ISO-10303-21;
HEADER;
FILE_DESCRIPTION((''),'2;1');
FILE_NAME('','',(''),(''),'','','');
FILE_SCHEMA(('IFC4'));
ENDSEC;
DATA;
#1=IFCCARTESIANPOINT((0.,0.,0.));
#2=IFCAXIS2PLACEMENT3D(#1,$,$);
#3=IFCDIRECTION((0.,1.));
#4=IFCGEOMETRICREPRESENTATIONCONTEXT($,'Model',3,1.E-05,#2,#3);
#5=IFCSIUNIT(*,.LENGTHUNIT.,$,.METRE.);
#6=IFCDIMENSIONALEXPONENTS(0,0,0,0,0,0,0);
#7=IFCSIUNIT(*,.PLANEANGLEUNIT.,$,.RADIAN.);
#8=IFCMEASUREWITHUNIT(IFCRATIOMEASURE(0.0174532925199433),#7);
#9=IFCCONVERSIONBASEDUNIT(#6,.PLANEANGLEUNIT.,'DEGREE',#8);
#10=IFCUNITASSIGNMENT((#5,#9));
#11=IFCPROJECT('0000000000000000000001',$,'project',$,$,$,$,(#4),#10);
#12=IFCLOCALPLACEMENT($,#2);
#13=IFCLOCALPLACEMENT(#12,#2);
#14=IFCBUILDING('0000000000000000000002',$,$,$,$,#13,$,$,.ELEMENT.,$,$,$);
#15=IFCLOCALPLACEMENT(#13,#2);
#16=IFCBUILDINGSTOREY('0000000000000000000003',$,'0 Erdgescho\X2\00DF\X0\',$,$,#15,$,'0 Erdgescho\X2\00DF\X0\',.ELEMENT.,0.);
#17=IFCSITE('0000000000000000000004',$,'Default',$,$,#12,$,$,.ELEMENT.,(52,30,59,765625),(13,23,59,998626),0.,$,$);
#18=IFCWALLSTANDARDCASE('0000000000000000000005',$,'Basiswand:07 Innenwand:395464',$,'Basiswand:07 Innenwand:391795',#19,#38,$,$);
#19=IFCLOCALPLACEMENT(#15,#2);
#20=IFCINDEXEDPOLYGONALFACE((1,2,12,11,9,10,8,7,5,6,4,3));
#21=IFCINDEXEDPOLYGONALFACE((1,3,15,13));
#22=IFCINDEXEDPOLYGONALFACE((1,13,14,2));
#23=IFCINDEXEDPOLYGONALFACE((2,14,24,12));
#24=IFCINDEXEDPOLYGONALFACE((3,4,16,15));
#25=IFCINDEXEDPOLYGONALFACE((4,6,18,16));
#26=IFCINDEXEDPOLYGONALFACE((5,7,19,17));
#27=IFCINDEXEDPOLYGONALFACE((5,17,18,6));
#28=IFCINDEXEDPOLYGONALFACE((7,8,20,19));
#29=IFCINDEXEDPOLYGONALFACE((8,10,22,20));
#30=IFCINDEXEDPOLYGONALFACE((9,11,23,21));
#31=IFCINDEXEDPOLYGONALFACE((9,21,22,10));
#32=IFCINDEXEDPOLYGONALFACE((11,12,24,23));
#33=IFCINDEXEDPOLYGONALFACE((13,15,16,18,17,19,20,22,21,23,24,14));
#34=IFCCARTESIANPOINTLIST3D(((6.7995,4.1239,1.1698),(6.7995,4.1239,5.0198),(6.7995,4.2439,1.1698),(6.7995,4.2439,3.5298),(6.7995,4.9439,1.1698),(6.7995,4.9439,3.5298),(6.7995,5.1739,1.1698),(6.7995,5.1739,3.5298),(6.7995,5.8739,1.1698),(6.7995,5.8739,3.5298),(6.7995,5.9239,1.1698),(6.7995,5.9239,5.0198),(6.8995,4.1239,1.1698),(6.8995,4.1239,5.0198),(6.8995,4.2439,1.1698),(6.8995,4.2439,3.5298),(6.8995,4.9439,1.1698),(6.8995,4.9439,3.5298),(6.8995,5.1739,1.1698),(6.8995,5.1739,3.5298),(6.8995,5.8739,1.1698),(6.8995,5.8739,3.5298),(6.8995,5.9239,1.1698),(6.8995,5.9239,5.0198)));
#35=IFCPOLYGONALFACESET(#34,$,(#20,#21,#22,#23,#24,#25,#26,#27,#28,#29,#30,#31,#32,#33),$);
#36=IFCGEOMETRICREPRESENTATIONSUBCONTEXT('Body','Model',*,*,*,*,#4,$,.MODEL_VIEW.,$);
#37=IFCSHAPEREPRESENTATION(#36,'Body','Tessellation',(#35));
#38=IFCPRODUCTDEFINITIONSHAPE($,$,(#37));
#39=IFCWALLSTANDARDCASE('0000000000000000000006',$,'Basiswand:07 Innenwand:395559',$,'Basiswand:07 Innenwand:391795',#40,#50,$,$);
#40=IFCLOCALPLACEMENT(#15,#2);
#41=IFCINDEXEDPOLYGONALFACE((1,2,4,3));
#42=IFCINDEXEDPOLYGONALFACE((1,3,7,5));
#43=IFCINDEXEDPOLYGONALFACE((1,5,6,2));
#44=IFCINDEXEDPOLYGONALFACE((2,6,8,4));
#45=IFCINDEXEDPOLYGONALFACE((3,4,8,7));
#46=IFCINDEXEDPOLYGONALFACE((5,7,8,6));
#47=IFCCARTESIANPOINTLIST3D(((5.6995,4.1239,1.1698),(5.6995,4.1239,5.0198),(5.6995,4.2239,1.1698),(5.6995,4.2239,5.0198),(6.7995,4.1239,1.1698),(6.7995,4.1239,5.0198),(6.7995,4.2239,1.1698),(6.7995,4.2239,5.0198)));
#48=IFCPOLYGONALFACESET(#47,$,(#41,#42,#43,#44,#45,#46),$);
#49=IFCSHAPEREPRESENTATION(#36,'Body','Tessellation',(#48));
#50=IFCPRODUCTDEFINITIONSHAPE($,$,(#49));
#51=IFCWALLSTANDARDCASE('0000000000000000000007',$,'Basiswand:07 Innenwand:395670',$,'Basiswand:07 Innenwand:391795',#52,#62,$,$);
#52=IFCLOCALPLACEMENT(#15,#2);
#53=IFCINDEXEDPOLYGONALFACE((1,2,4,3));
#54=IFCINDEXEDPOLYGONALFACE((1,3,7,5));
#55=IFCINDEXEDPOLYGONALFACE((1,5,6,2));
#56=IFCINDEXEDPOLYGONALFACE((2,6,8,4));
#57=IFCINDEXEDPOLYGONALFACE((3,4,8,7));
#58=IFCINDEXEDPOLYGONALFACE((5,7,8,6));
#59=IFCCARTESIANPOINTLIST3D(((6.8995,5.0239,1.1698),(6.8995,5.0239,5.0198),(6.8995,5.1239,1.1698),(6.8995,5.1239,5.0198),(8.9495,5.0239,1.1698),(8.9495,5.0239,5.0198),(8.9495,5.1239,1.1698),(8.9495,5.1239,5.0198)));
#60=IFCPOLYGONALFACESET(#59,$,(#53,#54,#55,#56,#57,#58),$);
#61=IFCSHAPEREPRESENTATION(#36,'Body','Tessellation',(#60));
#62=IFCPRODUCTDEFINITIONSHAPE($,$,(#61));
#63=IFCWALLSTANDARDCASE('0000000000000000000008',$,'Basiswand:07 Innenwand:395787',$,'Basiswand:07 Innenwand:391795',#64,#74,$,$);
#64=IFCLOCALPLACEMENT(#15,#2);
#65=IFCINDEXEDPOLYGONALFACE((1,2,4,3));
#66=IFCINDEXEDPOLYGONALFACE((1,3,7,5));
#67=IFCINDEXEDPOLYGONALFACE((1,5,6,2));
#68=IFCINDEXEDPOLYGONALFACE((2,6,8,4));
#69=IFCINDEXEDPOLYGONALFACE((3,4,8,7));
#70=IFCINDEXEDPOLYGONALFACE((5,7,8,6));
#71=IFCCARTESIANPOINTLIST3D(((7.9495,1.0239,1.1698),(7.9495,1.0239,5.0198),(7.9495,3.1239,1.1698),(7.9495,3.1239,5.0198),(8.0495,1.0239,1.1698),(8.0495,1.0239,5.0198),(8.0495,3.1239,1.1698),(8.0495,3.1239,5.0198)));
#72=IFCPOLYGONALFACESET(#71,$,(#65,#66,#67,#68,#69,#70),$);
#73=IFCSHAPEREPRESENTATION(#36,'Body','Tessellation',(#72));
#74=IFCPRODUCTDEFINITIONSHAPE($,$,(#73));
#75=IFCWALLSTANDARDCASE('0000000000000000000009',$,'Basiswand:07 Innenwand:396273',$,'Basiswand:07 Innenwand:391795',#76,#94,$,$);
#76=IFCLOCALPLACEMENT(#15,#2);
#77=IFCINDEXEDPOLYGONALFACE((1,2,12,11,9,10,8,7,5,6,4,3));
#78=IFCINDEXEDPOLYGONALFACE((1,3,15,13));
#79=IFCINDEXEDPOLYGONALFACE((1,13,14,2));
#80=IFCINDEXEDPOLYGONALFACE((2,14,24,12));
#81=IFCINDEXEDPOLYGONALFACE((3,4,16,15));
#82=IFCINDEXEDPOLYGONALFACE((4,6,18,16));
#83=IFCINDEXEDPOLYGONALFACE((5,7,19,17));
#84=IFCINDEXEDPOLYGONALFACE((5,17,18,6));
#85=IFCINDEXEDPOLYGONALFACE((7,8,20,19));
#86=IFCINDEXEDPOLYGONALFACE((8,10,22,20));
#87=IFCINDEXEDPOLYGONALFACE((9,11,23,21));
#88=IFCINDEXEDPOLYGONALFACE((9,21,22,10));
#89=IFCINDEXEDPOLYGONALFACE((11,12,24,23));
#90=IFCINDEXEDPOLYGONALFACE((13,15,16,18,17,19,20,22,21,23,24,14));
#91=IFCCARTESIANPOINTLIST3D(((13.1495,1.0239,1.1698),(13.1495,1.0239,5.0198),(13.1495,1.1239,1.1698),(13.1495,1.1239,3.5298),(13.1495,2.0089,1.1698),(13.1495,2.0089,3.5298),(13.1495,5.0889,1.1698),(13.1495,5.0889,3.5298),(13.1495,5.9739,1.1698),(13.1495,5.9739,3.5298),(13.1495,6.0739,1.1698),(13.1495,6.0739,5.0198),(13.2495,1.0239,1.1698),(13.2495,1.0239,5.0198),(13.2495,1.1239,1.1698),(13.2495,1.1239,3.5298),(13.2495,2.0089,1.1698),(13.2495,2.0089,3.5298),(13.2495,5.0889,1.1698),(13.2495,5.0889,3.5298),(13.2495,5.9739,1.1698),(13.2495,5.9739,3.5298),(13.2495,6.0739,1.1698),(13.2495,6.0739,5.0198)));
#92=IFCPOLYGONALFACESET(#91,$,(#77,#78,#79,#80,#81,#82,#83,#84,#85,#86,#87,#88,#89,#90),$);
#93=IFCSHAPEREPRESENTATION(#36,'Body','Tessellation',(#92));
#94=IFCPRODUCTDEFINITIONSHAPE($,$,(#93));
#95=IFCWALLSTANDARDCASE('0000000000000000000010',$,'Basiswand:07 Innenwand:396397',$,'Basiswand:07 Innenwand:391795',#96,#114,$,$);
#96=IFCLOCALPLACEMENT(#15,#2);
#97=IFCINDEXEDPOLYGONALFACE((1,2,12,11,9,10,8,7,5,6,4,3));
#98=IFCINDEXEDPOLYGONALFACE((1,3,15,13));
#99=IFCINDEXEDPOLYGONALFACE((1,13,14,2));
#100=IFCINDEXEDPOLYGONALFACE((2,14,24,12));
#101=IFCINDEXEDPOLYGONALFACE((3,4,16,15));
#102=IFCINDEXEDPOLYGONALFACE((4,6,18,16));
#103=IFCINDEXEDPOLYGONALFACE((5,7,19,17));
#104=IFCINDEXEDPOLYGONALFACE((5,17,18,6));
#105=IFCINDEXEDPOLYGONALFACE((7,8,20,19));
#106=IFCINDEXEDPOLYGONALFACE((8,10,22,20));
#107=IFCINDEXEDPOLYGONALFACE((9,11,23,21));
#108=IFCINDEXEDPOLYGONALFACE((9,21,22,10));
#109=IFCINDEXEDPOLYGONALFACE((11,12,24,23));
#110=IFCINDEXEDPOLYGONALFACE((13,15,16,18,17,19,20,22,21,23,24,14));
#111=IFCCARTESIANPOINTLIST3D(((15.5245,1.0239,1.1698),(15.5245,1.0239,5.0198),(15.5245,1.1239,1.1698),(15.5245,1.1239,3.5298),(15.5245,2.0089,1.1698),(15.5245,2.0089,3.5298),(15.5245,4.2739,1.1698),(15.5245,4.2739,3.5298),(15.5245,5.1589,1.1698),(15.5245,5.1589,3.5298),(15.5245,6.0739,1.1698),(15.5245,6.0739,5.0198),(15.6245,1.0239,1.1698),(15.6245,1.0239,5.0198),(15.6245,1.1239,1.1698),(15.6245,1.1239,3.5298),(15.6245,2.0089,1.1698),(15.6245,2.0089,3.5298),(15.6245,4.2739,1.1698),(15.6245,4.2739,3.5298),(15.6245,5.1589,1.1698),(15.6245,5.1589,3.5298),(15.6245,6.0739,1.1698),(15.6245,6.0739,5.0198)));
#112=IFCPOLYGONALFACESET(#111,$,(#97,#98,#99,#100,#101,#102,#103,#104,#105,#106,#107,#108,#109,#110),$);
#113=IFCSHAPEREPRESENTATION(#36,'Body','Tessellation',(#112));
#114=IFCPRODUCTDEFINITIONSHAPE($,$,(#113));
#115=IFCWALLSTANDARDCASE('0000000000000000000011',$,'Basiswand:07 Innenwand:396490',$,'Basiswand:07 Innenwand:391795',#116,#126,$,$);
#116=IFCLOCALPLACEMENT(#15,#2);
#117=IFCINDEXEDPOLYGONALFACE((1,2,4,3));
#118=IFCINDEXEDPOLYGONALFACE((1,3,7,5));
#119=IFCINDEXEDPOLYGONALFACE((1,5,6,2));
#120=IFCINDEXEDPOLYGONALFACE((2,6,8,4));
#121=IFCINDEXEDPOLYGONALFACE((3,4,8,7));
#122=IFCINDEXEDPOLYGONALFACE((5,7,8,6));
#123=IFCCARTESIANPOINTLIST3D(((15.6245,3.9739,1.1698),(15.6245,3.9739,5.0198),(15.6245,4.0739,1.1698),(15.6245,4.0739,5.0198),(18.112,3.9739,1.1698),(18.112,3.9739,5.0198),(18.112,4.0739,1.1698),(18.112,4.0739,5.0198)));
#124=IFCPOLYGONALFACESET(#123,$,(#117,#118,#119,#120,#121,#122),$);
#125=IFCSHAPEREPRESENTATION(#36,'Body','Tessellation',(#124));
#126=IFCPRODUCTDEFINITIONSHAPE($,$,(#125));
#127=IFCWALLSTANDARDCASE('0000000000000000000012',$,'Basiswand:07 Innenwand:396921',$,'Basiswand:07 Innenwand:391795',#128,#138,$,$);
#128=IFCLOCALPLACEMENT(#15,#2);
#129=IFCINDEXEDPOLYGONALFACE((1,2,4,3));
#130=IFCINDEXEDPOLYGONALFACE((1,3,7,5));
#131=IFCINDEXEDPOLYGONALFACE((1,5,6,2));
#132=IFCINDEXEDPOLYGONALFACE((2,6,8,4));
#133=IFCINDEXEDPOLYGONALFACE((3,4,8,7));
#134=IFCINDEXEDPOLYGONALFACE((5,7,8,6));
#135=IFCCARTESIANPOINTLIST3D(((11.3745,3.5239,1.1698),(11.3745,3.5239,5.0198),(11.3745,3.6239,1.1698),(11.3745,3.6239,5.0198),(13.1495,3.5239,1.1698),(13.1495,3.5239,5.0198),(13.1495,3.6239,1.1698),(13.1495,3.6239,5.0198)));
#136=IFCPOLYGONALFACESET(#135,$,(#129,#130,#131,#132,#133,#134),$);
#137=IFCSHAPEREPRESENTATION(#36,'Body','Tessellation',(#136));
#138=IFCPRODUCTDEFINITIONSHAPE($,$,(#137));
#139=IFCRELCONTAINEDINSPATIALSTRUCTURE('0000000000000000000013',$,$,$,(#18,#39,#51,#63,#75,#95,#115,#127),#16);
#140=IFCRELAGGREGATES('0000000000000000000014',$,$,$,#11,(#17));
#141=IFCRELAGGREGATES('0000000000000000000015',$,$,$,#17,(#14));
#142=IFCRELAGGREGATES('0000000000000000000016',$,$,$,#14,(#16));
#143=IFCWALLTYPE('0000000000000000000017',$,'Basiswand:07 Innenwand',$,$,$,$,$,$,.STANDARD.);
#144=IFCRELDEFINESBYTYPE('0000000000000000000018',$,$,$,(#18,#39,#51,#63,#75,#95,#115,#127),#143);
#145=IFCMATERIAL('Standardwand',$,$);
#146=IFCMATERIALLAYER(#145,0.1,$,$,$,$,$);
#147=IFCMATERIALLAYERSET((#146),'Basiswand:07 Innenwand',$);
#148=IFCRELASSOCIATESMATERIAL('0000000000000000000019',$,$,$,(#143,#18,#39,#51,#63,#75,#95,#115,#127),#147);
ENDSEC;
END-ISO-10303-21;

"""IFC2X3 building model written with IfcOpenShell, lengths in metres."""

from ifc_helpers import new_model, entity, si_unit, converted_unit, direction, frame, frame_2d, origin, place, context, subcontext, project, spatial, polyline, rectangle, extrude, clip, bounded_halfspace, material, layer, layer_set, layer_usage, type_object, element, save


model = new_model("IFC2X3")

# Units and contexts
model_context = context("Model", 3, precision=1e-05, world=origin(), true_north=direction((0.0, 1.0)))
body_context = subcontext(model_context, "Body", "Model", "MODEL_VIEW")
ifc_project = project(units=[si_unit("LENGTHUNIT", "METRE"), converted_unit("PLANEANGLEUNIT", "DEGREE", entity("IfcRatioMeasure", 0.0174532925199433), si_unit("PLANEANGLEUNIT", "RADIAN"), dimensions=[0, 0, 0, 0, 0, 0, 0])], contexts=[model_context])

# Site, building, storey
site_placement = place(None, origin())
site = spatial("IfcSite", under=ifc_project, at=site_placement, Name="Default", CompositionType="ELEMENT", RefLatitude=(52, 30, 59, 765625), RefLongitude=(13, 23, 59, 998626), RefElevation=0.0)
building_placement = place(site_placement, origin())
building = spatial("IfcBuilding", under=site, at=building_placement, CompositionType="ELEMENT")
storey_placement = place(building_placement, origin())
storey = spatial("IfcBuildingStorey", under=building, at=storey_placement, Name="0 Erdgeschoß", LongName="0 Erdgeschoß", CompositionType="ELEMENT", Elevation=0.0)

# Shared definitions
ifc_material_1 = material(Name="Standardwand")
ifc_layer_1 = layer(ifc_material_1, 0.1)
ifc_layer_set_1 = layer_set([ifc_layer_1], Name="Basiswand:07 Innenwand")
wall_type_1 = type_object("IfcWallType", Name="Basiswand:07 Innenwand", PredefinedType="STANDARD", material=ifc_layer_set_1)

# Wall, openings
ifc_layer_usage_1 = layer_usage(ifc_layer_set_1, "AXIS2", "POSITIVE", -0.05)
wall_1_placement = place(storey_placement, frame((6.8495, 5.9239, 1.1698), z_axis=(0.0, 0.0, 1.0), x_axis=(0.0, -1.0, 0.0)))
wall_1 = element("IfcWallStandardCase", 1, at=wall_1_placement, inside=storey, type_object=wall_type_1, material=ifc_layer_usage_1, Name="Basiswand:07 Innenwand:395464", ObjectType="Basiswand:07 Innenwand:391795", context=body_context, shape_type="Clipping", body=[
    clip(extrude(rectangle(XDim=1.8, YDim=0.1, at=frame_2d((0.9, 0.0), x_axis=(-1.0, 0.0))), origin(), (0.0, 0.0, 1.0), 3.85), bounded_halfspace(frame((0.0, -0.05, 3.85), z_axis=(0.0, 0.0, -1.0), x_axis=(1.0, 0.0, 0.0)), True, frame((0.0, -0.05, 3.85)), polyline([(0.0, 0.0), (1.7, 0.0), (1.8, 0.0), (1.8, 0.1), (0.9, 0.1), (0.8, 0.1), (0.0, 0.1), (0.0, 0.0)]))),
])
opening_1_placement = place(wall_1_placement, frame((0.98, -0.05, 0.0)))
element("IfcOpeningElement", 2, at=opening_1_placement, cuts=wall_1, ObjectType="Opening", context=body_context, shape_type="SweptSolid", body=[
    extrude(rectangle(XDim=2.36, YDim=0.7, at=frame_2d((1.18, 0.35), x_axis=(1.0, 0.0))), frame((0.0, 0.0, 0.0), z_axis=(0.0, 1.0, 0.0), x_axis=(0.0, 0.0, 1.0)), (0.0, 0.0, 1.0), 0.1),
])
opening_2_placement = place(wall_1_placement, frame((0.05, -0.05, 0.0)))
element("IfcOpeningElement", 3, at=opening_2_placement, cuts=wall_1, ObjectType="Opening", context=body_context, shape_type="SweptSolid", body=[
    extrude(rectangle(XDim=2.36, YDim=0.7, at=frame_2d((1.18, 0.35), x_axis=(1.0, 0.0))), frame((0.0, 0.0, 0.0), z_axis=(0.0, 1.0, 0.0), x_axis=(0.0, 0.0, 1.0)), (0.0, 0.0, 1.0), 0.1),
])

# Walls
ifc_layer_usage_2 = layer_usage(ifc_layer_set_1, "AXIS2", "POSITIVE", -0.05)
wall_2_placement = place(storey_placement, frame((6.7995, 4.1739, 1.1698), z_axis=(0.0, 0.0, 1.0), x_axis=(-1.0, 0.0, 0.0)))
element("IfcWallStandardCase", 4, at=wall_2_placement, inside=storey, type_object=wall_type_1, material=ifc_layer_usage_2, Name="Basiswand:07 Innenwand:395559", ObjectType="Basiswand:07 Innenwand:391795", context=body_context, shape_type="Clipping", body=[
    clip(extrude(rectangle(XDim=1.1, YDim=0.1, at=frame_2d((0.55, 0.0), x_axis=(-1.0, 0.0))), origin(), (0.0, 0.0, 1.0), 3.85), bounded_halfspace(frame((0.0, -0.05, 3.85), z_axis=(0.0, 0.0, -1.0), x_axis=(0.0, 1.0, 0.0)), True, frame((0.0, -0.05, 3.85)), polyline([(0.0, 0.0), (1.1, 0.0), (1.1, 0.1), (0.0, 0.1), (0.0, 0.0)]))),
])
ifc_layer_usage_3 = layer_usage(ifc_layer_set_1, "AXIS2", "POSITIVE", -0.05)
wall_3_placement = place(storey_placement, frame((6.8995, 5.0739, 1.1698), z_axis=(0.0, 0.0, 1.0), x_axis=(1.0, 0.0, 0.0)))
element("IfcWallStandardCase", 5, at=wall_3_placement, inside=storey, type_object=wall_type_1, material=ifc_layer_usage_3, Name="Basiswand:07 Innenwand:395670", ObjectType="Basiswand:07 Innenwand:391795", context=body_context, shape_type="Clipping", body=[
    clip(extrude(rectangle(XDim=2.05, YDim=0.1, at=frame_2d((1.025, 0.0), x_axis=(-1.0, 0.0))), origin(), (0.0, 0.0, 1.0), 3.85), bounded_halfspace(frame((0.0, -0.05, 3.85), z_axis=(0.0, 0.0, -1.0), x_axis=(0.0, -1.0, 0.0)), True, frame((0.0, -0.05, 3.85)), polyline([(0.0, 0.0), (2.05, 0.0), (2.05, 0.1), (0.0, 0.1), (0.0, 0.0)]))),
])
ifc_layer_usage_4 = layer_usage(ifc_layer_set_1, "AXIS2", "POSITIVE", -0.05)
wall_4_placement = place(storey_placement, frame((7.9995, 3.1239, 1.1698), z_axis=(0.0, 0.0, 1.0), x_axis=(0.0, -1.0, 0.0)))
element("IfcWallStandardCase", 6, at=wall_4_placement, inside=storey, type_object=wall_type_1, material=ifc_layer_usage_4, Name="Basiswand:07 Innenwand:395787", ObjectType="Basiswand:07 Innenwand:391795", context=body_context, shape_type="Clipping", body=[
    clip(extrude(rectangle(XDim=2.1, YDim=0.1, at=frame_2d((1.05, 0.0), x_axis=(-1.0, 0.0))), origin(), (0.0, 0.0, 1.0), 3.85), bounded_halfspace(frame((0.0, -0.05, 3.85), z_axis=(0.0, 0.0, -1.0), x_axis=(1.0, 0.0, 0.0)), True, frame((0.0, -0.05, 3.85)), polyline([(0.0, 0.0), (2.1, 0.0), (2.1, 0.1), (0.0, 0.1), (0.0, 0.0)]))),
])

# Walls, openings
ifc_layer_usage_5 = layer_usage(ifc_layer_set_1, "AXIS2", "NEGATIVE", 0.05)
wall_5_placement = place(storey_placement, frame((13.1995, 1.0239, 1.1698), z_axis=(0.0, 0.0, 1.0), x_axis=(0.0, 1.0, 0.0)))
wall_5 = element("IfcWallStandardCase", 7, at=wall_5_placement, inside=storey, type_object=wall_type_1, material=ifc_layer_usage_5, Name="Basiswand:07 Innenwand:396273", ObjectType="Basiswand:07 Innenwand:391795", context=body_context, shape_type="Clipping", body=[
    clip(extrude(rectangle(XDim=5.05, YDim=0.1, at=frame_2d((2.525, 0.0), x_axis=(-1.0, 0.0))), origin(), (0.0, 0.0, 1.0), 3.85), bounded_halfspace(frame((0.0, -0.05, 3.85), z_axis=(0.0, 0.0, -1.0), x_axis=(-1.0, 0.0, 0.0)), True, frame((0.0, -0.05, 3.85)), polyline([(0.0, 0.0), (5.05, 0.0), (5.05, 0.1), (2.6, 0.1), (2.5, 0.1), (0.0, 0.1), (0.0, 0.0)]))),
])
opening_3_placement = place(wall_5_placement, frame((0.985, 0.05, 0.0)))
element("IfcOpeningElement", 8, at=opening_3_placement, cuts=wall_5, ObjectType="Opening", context=body_context, shape_type="SweptSolid", body=[
    extrude(rectangle(XDim=2.36, YDim=0.885, at=frame_2d((1.18, 0.4425), x_axis=(1.0, 0.0))), frame((0.0, 0.0, 0.0), z_axis=(0.0, -1.0, 0.0), x_axis=(0.0, 0.0, 1.0)), (0.0, 0.0, 1.0), 0.1),
])
opening_4_placement = place(wall_5_placement, frame((4.95, 0.05, 0.0)))
element("IfcOpeningElement", 9, at=opening_4_placement, cuts=wall_5, ObjectType="Opening", context=body_context, shape_type="SweptSolid", body=[
    extrude(rectangle(XDim=2.36, YDim=0.885, at=frame_2d((1.18, 0.4425), x_axis=(1.0, 0.0))), frame((0.0, 0.0, 0.0), z_axis=(0.0, -1.0, 0.0), x_axis=(0.0, 0.0, 1.0)), (0.0, 0.0, 1.0), 0.1),
])
ifc_layer_usage_6 = layer_usage(ifc_layer_set_1, "AXIS2", "NEGATIVE", 0.05)
wall_6_placement = place(storey_placement, frame((15.5745, 1.0239, 1.1698), z_axis=(0.0, 0.0, 1.0), x_axis=(0.0, 1.0, 0.0)))
wall_6 = element("IfcWallStandardCase", 10, at=wall_6_placement, inside=storey, type_object=wall_type_1, material=ifc_layer_usage_6, Name="Basiswand:07 Innenwand:396397", ObjectType="Basiswand:07 Innenwand:391795", context=body_context, shape_type="Clipping", body=[
    clip(extrude(rectangle(XDim=5.05, YDim=0.1, at=frame_2d((2.525, 0.0), x_axis=(-1.0, 0.0))), origin(), (0.0, 0.0, 1.0), 3.85), bounded_halfspace(frame((0.0, -0.05, 3.85), z_axis=(0.0, 0.0, -1.0), x_axis=(-1.0, 0.0, 0.0)), True, frame((0.0, -0.05, 3.85)), polyline([(0.0, 0.0), (2.95, 0.0), (3.05, 0.0), (5.05, 0.0), (5.05, 0.1), (0.0, 0.1), (0.0, 0.0)]))),
])
opening_5_placement = place(wall_6_placement, frame((3.25, -0.05, 0.0)))
element("IfcOpeningElement", 11, at=opening_5_placement, cuts=wall_6, ObjectType="Opening", context=body_context, shape_type="SweptSolid", body=[
    extrude(rectangle(XDim=2.36, YDim=0.885, at=frame_2d((1.18, 0.4425), x_axis=(1.0, 0.0))), frame((0.0, 0.0, 0.0), z_axis=(0.0, 1.0, 0.0), x_axis=(0.0, 0.0, 1.0)), (0.0, 0.0, 1.0), 0.1),
])
opening_6_placement = place(wall_6_placement, frame((0.985, 0.05, 0.0)))
element("IfcOpeningElement", 12, at=opening_6_placement, cuts=wall_6, ObjectType="Opening", context=body_context, shape_type="SweptSolid", body=[
    extrude(rectangle(XDim=2.36, YDim=0.885, at=frame_2d((1.18, 0.4425), x_axis=(1.0, 0.0))), frame((0.0, 0.0, 0.0), z_axis=(0.0, -1.0, 0.0), x_axis=(0.0, 0.0, 1.0)), (0.0, 0.0, 1.0), 0.1),
])

# Walls
ifc_layer_usage_7 = layer_usage(ifc_layer_set_1, "AXIS2", "POSITIVE", -0.05)
wall_7_placement = place(storey_placement, frame((15.6245, 4.0239, 1.1698), z_axis=(0.0, 0.0, 1.0), x_axis=(1.0, 0.0, 0.0)))
element("IfcWallStandardCase", 13, at=wall_7_placement, inside=storey, type_object=wall_type_1, material=ifc_layer_usage_7, Name="Basiswand:07 Innenwand:396490", ObjectType="Basiswand:07 Innenwand:391795", context=body_context, shape_type="Clipping", body=[
    clip(extrude(rectangle(XDim=2.4875, YDim=0.1, at=frame_2d((1.2438, 0.0), x_axis=(-1.0, 0.0))), origin(), (0.0, 0.0, 1.0), 3.85), bounded_halfspace(frame((0.0, -0.05, 3.85), z_axis=(0.0, 0.0, -1.0), x_axis=(0.0, -1.0, 0.0)), True, frame((0.0, -0.05, 3.85)), polyline([(0.0, 0.0), (2.4875, 0.0), (2.4875, 0.1), (2.3875, 0.1), (0.0, 0.1), (0.0, 0.0)]))),
])
ifc_layer_usage_8 = layer_usage(ifc_layer_set_1, "AXIS2", "POSITIVE", -0.05)
wall_8_placement = place(storey_placement, frame((11.3745, 3.5739, 1.1698), z_axis=(0.0, 0.0, 1.0), x_axis=(1.0, 0.0, 0.0)))
element("IfcWallStandardCase", 14, at=wall_8_placement, inside=storey, type_object=wall_type_1, material=ifc_layer_usage_8, Name="Basiswand:07 Innenwand:396921", ObjectType="Basiswand:07 Innenwand:391795", context=body_context, shape_type="Clipping", body=[
    clip(extrude(rectangle(XDim=1.775, YDim=0.1, at=frame_2d((0.8875, 0.0), x_axis=(-1.0, 0.0))), origin(), (0.0, 0.0, 1.0), 3.85), bounded_halfspace(frame((0.0, -0.05, 3.85), z_axis=(0.0, 0.0, -1.0), x_axis=(0.0, -1.0, 0.0)), True, frame((0.0, -0.05, 3.85)), polyline([(0.0, 0.0), (1.775, 0.0), (1.775, 0.1), (0.0, 0.1), (0.0, 0.0)]))),
])

save(model, "model.ifc")
